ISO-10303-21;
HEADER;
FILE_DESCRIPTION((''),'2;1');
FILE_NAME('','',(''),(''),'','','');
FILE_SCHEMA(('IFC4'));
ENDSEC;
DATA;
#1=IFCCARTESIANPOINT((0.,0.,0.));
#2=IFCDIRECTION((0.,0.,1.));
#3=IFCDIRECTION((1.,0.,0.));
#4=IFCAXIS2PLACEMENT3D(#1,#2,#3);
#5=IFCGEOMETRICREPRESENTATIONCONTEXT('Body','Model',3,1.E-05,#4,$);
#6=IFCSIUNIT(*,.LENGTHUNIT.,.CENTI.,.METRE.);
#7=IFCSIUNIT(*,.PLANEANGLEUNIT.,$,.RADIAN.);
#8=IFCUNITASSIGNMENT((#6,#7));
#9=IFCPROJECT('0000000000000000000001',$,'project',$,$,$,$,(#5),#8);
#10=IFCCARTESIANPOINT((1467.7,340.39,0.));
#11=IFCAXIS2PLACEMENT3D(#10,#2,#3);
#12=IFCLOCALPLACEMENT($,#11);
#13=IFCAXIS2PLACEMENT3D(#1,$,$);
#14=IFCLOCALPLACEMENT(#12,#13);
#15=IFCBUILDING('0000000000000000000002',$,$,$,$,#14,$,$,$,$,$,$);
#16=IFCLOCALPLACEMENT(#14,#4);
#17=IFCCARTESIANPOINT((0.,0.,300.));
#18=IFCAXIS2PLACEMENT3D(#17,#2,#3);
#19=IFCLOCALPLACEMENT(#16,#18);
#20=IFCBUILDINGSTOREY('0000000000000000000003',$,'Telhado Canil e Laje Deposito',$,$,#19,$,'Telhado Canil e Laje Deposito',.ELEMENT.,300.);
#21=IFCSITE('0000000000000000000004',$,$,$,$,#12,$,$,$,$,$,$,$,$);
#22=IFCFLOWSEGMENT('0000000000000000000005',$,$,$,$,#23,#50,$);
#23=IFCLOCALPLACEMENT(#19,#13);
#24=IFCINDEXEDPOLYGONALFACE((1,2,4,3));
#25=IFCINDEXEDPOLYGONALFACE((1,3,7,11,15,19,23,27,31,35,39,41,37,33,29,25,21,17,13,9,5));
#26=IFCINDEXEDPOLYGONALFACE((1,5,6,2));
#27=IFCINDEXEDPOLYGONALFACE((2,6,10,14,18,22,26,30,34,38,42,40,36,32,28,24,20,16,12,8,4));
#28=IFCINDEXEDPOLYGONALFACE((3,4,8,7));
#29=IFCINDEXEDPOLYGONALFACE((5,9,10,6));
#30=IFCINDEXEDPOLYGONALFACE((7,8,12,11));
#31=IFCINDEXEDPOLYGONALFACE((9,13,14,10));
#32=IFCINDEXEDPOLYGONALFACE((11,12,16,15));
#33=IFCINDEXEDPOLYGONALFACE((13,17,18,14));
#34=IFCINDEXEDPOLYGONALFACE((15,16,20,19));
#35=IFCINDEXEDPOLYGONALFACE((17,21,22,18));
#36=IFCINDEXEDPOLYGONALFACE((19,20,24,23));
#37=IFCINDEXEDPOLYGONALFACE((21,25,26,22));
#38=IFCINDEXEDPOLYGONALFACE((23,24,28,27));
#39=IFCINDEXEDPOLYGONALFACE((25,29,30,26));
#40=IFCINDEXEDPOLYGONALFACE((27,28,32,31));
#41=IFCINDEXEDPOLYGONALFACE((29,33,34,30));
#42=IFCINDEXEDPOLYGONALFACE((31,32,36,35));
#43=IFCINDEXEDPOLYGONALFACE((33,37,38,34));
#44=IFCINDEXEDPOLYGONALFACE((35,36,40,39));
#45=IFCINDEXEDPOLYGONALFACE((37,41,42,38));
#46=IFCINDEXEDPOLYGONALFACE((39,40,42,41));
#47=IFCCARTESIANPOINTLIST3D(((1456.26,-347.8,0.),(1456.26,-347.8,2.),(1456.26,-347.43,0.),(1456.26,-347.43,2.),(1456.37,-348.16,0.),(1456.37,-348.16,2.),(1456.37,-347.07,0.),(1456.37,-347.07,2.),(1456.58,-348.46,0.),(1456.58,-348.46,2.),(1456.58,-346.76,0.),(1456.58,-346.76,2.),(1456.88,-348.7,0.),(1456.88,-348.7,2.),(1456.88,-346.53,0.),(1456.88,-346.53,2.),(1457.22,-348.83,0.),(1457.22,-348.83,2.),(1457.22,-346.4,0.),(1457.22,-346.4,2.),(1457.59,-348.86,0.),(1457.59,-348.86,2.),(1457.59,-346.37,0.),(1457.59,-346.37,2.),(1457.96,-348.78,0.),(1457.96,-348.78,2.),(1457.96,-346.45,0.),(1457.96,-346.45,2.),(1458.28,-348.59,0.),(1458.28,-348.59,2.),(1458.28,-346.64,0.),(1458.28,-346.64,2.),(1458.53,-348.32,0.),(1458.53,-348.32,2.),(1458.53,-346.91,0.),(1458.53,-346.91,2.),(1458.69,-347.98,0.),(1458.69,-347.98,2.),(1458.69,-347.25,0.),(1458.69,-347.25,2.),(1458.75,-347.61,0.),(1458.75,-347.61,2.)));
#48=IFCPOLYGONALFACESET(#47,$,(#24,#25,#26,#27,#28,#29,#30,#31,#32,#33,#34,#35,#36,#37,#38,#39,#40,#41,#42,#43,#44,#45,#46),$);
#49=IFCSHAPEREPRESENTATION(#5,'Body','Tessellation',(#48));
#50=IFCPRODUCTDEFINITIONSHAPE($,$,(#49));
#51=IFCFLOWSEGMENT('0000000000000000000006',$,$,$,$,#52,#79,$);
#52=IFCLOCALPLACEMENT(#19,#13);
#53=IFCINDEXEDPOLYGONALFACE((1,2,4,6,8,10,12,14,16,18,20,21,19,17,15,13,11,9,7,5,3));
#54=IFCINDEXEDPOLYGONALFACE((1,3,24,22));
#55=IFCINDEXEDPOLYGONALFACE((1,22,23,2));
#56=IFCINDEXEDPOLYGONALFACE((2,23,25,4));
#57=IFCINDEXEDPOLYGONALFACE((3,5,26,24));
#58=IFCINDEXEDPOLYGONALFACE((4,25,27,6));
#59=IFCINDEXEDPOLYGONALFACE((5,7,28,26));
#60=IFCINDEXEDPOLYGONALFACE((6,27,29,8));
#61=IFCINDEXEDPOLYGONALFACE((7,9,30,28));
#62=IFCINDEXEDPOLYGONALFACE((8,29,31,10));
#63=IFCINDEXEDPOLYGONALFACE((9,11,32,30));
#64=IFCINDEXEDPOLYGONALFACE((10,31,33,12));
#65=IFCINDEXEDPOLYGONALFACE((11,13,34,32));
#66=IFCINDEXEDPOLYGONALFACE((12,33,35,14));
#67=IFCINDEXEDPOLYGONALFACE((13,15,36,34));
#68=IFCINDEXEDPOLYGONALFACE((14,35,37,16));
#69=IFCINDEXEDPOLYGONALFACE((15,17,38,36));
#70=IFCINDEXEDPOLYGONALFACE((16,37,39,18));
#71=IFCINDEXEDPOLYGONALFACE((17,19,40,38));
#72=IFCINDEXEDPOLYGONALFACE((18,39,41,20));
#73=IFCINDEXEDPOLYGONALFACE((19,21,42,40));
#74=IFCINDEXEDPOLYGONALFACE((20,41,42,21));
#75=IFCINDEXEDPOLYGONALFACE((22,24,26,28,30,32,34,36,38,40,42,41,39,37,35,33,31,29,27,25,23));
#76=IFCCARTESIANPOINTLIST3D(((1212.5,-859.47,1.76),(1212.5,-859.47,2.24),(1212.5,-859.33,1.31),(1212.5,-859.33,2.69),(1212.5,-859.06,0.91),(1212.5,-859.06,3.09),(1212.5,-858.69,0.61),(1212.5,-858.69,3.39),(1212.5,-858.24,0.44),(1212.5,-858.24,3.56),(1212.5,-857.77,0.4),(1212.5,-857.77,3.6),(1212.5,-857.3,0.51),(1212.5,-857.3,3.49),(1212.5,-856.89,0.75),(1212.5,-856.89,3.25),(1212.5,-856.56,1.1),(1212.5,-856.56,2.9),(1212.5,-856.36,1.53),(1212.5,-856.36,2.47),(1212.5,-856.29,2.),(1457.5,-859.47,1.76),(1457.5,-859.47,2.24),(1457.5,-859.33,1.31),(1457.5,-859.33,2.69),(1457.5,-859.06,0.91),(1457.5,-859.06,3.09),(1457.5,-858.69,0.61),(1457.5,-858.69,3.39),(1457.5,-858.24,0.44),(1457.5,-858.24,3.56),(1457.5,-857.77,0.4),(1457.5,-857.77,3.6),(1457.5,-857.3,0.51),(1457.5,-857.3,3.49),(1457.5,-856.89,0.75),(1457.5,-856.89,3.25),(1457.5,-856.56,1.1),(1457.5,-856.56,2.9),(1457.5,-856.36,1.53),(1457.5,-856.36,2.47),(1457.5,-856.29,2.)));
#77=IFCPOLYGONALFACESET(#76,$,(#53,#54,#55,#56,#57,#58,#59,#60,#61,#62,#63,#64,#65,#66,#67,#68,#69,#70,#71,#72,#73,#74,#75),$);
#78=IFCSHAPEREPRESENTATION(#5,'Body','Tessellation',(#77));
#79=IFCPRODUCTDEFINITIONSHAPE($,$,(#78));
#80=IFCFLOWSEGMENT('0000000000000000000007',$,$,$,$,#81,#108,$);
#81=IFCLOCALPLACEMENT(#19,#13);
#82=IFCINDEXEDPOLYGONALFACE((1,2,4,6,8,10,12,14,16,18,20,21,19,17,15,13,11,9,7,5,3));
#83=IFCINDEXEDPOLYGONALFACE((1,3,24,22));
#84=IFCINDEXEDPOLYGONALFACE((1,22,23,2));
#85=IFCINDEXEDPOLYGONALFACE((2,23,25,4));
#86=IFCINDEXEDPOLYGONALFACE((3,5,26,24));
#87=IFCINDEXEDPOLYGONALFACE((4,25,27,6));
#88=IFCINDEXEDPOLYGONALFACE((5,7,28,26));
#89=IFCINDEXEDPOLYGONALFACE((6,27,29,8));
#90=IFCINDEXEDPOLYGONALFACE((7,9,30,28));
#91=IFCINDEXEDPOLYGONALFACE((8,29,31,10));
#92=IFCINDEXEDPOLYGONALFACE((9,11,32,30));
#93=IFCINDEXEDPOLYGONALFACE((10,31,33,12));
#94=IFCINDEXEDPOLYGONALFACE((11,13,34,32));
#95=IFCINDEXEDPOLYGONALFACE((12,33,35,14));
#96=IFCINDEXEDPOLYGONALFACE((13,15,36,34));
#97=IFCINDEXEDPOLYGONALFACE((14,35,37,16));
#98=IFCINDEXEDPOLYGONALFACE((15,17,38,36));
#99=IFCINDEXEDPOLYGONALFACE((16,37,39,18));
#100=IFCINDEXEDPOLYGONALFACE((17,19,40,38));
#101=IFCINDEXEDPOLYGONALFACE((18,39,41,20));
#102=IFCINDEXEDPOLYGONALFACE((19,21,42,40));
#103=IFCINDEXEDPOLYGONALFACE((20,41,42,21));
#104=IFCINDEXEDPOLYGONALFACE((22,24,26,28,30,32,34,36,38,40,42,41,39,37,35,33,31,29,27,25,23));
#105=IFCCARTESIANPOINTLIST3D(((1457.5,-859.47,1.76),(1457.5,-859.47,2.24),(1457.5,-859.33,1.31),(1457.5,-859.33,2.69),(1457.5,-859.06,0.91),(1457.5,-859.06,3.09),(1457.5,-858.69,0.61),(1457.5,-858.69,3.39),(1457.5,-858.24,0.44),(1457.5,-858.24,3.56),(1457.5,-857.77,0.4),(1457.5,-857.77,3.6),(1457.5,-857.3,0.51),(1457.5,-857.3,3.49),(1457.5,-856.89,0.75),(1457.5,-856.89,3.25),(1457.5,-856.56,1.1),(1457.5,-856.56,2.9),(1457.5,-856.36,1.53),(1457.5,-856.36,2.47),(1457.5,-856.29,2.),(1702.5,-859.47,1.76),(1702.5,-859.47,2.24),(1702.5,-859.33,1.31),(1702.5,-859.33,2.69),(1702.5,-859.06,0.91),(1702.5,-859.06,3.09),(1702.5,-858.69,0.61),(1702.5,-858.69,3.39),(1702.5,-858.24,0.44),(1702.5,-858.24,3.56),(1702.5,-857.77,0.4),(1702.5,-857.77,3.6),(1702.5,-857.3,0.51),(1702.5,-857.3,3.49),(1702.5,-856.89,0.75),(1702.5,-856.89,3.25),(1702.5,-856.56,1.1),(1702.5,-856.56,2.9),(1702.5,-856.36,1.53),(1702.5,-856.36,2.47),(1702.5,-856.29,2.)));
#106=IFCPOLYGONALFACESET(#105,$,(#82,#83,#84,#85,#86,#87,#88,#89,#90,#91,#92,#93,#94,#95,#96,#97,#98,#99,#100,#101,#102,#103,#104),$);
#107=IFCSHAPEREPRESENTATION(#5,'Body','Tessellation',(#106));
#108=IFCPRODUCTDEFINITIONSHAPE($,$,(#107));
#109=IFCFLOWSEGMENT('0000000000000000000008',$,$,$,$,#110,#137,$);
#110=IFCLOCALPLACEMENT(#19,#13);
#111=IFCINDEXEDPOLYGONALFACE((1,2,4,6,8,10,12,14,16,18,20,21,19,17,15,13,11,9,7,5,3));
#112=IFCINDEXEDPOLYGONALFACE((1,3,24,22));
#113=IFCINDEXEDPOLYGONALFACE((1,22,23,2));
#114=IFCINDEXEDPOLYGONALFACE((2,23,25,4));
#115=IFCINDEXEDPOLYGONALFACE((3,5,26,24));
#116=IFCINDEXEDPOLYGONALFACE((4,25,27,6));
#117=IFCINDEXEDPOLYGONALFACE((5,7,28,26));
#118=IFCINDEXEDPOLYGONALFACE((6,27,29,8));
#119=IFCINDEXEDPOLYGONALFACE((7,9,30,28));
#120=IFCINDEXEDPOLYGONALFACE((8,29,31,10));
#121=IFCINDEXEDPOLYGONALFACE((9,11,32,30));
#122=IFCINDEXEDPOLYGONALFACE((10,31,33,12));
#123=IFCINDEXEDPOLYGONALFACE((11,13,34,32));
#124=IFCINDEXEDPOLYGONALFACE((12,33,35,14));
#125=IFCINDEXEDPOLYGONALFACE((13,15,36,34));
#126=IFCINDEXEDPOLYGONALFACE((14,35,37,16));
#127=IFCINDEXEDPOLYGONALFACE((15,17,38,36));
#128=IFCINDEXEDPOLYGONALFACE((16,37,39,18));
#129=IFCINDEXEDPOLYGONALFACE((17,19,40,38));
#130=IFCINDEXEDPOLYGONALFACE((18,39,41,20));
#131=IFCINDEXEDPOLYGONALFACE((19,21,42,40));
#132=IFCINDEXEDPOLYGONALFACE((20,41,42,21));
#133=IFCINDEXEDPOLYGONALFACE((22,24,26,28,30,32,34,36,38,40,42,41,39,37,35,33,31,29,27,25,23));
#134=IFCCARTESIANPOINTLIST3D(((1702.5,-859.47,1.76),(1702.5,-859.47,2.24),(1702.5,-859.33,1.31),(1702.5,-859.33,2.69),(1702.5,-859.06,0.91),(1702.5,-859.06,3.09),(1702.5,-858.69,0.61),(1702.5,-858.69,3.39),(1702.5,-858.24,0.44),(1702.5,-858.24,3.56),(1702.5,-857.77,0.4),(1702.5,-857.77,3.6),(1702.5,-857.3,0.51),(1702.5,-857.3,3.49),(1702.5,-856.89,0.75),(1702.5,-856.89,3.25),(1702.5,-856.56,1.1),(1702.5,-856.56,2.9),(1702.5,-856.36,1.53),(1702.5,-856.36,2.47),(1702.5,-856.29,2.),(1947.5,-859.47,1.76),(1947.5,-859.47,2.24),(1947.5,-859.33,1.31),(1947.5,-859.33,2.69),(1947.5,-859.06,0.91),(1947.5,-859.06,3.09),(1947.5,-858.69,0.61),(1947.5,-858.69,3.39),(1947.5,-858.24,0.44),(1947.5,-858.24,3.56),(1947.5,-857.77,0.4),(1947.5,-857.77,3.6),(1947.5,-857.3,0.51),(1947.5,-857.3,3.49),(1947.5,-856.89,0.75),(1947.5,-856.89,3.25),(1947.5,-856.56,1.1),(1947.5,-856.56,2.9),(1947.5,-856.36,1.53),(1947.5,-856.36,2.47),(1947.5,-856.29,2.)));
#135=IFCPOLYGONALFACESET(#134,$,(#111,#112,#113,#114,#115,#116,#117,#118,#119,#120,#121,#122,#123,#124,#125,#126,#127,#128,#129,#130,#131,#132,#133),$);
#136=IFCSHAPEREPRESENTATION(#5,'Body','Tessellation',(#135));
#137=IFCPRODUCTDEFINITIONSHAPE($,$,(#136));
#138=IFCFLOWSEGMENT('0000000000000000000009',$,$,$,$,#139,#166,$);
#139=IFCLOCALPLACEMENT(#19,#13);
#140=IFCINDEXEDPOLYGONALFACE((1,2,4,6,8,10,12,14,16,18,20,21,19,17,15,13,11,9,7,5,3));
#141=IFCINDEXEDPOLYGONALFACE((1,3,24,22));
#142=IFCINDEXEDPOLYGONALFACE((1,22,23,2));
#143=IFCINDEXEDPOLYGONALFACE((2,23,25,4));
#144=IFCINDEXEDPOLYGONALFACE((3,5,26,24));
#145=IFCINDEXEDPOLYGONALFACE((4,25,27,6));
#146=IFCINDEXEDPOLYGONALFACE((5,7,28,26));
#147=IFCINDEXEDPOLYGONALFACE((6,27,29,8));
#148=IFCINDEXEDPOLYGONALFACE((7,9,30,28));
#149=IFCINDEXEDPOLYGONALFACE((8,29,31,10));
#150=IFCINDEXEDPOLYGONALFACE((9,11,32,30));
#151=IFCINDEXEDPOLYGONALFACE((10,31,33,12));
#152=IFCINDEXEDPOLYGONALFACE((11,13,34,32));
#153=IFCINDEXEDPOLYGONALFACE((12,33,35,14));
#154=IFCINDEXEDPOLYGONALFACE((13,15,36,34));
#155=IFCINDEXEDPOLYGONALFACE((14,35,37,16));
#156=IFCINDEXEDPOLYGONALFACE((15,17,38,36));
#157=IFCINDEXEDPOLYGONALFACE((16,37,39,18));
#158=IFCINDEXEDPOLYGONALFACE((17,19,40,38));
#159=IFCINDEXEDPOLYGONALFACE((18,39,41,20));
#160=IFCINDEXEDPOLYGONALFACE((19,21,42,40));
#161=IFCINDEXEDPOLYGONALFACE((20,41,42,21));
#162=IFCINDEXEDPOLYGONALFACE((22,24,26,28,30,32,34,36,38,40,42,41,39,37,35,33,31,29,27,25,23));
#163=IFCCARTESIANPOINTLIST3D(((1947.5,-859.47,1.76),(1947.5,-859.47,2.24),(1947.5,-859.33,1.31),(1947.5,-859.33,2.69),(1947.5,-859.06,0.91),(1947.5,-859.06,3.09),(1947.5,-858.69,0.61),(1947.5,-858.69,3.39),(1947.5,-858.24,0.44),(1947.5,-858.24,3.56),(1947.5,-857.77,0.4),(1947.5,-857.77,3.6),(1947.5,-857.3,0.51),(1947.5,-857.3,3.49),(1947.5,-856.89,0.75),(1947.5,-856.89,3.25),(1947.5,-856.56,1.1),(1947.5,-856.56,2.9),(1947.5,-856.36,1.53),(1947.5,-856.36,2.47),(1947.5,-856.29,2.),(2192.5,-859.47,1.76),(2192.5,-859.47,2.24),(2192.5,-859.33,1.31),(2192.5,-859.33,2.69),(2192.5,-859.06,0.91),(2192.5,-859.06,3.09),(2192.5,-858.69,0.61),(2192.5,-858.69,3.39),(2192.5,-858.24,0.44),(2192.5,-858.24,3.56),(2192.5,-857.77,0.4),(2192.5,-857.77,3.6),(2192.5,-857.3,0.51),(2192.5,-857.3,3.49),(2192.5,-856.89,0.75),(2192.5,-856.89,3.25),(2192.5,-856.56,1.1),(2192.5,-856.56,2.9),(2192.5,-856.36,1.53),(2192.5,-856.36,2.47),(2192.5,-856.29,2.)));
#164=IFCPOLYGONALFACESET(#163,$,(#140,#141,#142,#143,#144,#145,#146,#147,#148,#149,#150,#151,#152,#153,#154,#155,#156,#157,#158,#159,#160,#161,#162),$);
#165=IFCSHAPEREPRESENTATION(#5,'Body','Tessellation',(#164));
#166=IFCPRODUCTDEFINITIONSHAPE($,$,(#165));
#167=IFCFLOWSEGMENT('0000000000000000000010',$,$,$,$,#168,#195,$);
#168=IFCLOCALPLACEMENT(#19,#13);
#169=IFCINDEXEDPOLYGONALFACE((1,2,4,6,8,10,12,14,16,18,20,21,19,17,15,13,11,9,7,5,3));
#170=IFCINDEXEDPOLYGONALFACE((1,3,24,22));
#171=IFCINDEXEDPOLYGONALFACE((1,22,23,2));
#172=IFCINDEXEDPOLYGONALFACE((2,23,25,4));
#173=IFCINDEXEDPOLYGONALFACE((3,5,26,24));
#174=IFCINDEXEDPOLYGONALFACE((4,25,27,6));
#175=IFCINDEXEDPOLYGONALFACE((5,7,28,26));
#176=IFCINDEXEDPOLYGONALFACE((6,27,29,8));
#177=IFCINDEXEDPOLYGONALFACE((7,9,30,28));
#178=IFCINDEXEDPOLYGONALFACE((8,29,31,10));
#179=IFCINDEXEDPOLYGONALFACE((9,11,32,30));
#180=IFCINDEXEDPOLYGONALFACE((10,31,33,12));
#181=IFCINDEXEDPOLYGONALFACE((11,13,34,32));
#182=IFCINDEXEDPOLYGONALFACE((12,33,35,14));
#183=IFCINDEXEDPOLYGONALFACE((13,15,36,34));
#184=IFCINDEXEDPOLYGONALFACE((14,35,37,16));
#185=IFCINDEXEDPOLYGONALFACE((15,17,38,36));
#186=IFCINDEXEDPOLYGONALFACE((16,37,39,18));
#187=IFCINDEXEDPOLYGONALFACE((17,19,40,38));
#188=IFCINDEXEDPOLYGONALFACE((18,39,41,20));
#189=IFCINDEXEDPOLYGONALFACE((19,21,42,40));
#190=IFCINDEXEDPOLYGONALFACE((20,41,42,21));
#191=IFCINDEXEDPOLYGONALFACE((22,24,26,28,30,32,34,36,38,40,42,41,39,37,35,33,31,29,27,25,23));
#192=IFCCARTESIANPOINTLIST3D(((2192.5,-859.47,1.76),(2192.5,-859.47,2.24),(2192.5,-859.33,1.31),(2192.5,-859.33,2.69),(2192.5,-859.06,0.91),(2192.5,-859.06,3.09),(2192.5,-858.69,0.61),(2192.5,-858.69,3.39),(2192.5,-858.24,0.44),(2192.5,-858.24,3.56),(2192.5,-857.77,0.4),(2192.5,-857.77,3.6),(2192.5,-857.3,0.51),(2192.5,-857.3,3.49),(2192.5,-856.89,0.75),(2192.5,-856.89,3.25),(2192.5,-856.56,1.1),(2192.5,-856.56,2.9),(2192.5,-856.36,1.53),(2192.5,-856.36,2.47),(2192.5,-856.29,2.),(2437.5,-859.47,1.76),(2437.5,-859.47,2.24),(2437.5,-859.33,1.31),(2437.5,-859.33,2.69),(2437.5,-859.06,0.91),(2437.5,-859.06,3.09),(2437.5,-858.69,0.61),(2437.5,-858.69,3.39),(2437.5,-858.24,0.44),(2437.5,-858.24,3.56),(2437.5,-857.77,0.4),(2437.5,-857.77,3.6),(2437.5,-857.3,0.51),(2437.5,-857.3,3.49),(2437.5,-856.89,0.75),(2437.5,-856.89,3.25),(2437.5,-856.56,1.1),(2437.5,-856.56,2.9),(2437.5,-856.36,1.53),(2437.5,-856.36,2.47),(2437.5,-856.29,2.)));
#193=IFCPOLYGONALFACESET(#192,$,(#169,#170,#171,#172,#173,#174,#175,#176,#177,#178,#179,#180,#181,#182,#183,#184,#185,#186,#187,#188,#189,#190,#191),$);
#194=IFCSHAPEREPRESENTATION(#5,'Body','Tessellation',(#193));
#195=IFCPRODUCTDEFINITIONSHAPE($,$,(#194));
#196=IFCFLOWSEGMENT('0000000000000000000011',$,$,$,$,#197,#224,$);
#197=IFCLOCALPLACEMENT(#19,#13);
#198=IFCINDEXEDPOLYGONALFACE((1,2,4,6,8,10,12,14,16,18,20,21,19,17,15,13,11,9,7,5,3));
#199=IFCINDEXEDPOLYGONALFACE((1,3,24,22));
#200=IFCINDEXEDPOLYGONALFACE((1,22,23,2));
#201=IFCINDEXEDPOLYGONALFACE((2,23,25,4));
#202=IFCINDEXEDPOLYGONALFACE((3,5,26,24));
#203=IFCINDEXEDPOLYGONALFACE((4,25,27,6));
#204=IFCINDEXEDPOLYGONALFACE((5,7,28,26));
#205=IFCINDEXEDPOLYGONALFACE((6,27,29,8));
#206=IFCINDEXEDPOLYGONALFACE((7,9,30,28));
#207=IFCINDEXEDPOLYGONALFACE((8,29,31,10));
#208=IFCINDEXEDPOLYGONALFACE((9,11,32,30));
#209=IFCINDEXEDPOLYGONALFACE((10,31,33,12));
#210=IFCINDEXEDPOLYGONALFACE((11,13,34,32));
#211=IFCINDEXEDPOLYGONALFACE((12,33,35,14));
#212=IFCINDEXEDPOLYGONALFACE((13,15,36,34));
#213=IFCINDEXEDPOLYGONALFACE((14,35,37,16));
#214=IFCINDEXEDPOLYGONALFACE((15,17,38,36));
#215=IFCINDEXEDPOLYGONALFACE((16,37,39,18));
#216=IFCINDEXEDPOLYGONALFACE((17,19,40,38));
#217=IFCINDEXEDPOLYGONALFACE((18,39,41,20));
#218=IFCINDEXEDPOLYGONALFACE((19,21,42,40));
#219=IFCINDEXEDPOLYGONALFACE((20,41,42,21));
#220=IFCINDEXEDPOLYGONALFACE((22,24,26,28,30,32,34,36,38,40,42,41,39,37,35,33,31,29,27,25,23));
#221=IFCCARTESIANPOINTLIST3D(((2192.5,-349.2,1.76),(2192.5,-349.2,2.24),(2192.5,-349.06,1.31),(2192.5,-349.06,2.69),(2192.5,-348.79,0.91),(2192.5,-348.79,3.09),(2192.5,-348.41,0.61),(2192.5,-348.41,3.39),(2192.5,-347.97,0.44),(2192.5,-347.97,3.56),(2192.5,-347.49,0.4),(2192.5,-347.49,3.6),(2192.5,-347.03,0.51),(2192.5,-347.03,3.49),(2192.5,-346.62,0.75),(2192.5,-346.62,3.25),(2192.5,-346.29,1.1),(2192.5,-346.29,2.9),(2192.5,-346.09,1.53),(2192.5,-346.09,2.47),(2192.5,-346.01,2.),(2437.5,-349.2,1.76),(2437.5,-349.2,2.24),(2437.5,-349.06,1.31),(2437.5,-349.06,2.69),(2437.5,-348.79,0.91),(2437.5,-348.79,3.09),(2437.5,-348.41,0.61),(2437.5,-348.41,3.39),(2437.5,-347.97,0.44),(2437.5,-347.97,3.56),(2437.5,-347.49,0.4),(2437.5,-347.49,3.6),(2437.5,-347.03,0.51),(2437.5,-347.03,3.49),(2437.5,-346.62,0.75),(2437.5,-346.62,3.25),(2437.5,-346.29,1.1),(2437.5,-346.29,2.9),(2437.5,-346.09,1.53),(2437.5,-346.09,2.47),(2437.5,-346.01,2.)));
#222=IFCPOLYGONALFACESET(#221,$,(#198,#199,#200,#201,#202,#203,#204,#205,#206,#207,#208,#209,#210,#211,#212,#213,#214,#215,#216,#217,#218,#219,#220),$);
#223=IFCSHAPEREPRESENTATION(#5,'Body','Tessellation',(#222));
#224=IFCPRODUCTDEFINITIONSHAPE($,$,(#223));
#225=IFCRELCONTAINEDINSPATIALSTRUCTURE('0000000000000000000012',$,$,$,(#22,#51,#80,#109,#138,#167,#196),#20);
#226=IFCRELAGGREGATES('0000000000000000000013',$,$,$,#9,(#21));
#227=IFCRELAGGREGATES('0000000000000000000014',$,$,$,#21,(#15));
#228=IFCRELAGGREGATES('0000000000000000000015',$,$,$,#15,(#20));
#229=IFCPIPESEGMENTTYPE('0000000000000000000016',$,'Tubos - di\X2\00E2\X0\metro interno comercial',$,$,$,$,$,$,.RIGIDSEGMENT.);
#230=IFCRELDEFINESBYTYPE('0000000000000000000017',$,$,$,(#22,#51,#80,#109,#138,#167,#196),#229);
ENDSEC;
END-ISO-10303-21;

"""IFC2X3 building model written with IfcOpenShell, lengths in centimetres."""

from ifc_helpers import new_model, si_unit, frame, origin, origin_with_axes, origin_2d_with_axis, place, context, project, spatial, circle, extrude, type_object, element, save


model = new_model("IFC2X3")

# Units and contexts
model_context = context("Model", 3, precision=1e-05, world=origin_with_axes(), identifier="Body")
ifc_project = project(units=[si_unit("LENGTHUNIT", "METRE", prefix="CENTI"), si_unit("PLANEANGLEUNIT", "RADIAN")], contexts=[model_context])

# Site, building, storey
site_placement = place(None, frame((1467.7, 340.39, 0.0), z_axis=(0.0, 0.0, 1.0), x_axis=(1.0, 0.0, 0.0)))
site = spatial("IfcSite", under=ifc_project, at=site_placement)
building_placement = place(site_placement, origin())
building = spatial("IfcBuilding", under=site, at=building_placement)
placement = place(building_placement, origin_with_axes())
storey_placement = place(placement, frame((0.0, 0.0, 300.0), z_axis=(0.0, 0.0, 1.0), x_axis=(1.0, 0.0, 0.0)))
storey = spatial("IfcBuildingStorey", under=building, at=storey_placement, Name="Telhado Canil e Laje Deposito", LongName="Telhado Canil e Laje Deposito", CompositionType="ELEMENT", Elevation=300.0)

# Flow segments
pipe_segment_type_1 = type_object("IfcPipeSegmentType", Name="Tubos - diâmetro interno comercial", PredefinedType="RIGIDSEGMENT")
flow_segment_1_placement = place(storey_placement, frame((1457.5, -347.61, 2.0), z_axis=(0.0, 0.0, 1.0), x_axis=(1.0, 0.0, 0.0)))
element("IfcFlowSegment", 1, at=flow_segment_1_placement, inside=storey, type_object=pipe_segment_type_1, context=model_context, shape_type="SolidModel", body=[
    extrude(circle(Radius=1.25, at=origin_2d_with_axis()), frame((0.0, 0.0, 0.0), z_axis=(0.0, 0.0, -1.0), x_axis=(1.0, 0.0, 0.0)), (0.0, 0.0, 1.0), 2.0),
])
for number, where, z_axis, x_axis in (
    (2, (1335.0, -857.89, 3.6), (0.0, 0.0, 1.0), (1.0, 0.0, 0.0)),
    (3, (1580.0, -857.89, 3.6), (0.0, 0.0, 1.0), (1.0, 0.0, 0.0)),
    (4, (1825.0, -857.89, 3.6), (0.0, 0.0, 1.0), (1.0, 0.0, 0.0)),
    (5, (2070.0, -857.89, 3.6), (0.0, 0.0, 1.0), (1.0, 0.0, 0.0)),
    (6, (2315.0, -857.89, 3.6), (0.0, 0.0, 1.0), (1.0, 0.0, 0.0)),
    (7, (2315.0, -347.61, 3.6), (0.0, 0.0, 1.0), (1.0, 0.0, 0.0)),
):
    element("IfcFlowSegment", number, at=place(storey_placement, frame(where, z_axis=z_axis, x_axis=x_axis)), inside=storey, type_object=pipe_segment_type_1, context=model_context, shape_type="SolidModel", body=[
        extrude(circle(Radius=1.6, at=origin_2d_with_axis()), frame((122.5, 0.0, -1.6), z_axis=(-1.0, 0.0, 0.0), x_axis=(0.0, 1.0, 0.0)), (0.0, 0.0, 1.0), 245.0),
    ])

save(model, "model.ifc")
